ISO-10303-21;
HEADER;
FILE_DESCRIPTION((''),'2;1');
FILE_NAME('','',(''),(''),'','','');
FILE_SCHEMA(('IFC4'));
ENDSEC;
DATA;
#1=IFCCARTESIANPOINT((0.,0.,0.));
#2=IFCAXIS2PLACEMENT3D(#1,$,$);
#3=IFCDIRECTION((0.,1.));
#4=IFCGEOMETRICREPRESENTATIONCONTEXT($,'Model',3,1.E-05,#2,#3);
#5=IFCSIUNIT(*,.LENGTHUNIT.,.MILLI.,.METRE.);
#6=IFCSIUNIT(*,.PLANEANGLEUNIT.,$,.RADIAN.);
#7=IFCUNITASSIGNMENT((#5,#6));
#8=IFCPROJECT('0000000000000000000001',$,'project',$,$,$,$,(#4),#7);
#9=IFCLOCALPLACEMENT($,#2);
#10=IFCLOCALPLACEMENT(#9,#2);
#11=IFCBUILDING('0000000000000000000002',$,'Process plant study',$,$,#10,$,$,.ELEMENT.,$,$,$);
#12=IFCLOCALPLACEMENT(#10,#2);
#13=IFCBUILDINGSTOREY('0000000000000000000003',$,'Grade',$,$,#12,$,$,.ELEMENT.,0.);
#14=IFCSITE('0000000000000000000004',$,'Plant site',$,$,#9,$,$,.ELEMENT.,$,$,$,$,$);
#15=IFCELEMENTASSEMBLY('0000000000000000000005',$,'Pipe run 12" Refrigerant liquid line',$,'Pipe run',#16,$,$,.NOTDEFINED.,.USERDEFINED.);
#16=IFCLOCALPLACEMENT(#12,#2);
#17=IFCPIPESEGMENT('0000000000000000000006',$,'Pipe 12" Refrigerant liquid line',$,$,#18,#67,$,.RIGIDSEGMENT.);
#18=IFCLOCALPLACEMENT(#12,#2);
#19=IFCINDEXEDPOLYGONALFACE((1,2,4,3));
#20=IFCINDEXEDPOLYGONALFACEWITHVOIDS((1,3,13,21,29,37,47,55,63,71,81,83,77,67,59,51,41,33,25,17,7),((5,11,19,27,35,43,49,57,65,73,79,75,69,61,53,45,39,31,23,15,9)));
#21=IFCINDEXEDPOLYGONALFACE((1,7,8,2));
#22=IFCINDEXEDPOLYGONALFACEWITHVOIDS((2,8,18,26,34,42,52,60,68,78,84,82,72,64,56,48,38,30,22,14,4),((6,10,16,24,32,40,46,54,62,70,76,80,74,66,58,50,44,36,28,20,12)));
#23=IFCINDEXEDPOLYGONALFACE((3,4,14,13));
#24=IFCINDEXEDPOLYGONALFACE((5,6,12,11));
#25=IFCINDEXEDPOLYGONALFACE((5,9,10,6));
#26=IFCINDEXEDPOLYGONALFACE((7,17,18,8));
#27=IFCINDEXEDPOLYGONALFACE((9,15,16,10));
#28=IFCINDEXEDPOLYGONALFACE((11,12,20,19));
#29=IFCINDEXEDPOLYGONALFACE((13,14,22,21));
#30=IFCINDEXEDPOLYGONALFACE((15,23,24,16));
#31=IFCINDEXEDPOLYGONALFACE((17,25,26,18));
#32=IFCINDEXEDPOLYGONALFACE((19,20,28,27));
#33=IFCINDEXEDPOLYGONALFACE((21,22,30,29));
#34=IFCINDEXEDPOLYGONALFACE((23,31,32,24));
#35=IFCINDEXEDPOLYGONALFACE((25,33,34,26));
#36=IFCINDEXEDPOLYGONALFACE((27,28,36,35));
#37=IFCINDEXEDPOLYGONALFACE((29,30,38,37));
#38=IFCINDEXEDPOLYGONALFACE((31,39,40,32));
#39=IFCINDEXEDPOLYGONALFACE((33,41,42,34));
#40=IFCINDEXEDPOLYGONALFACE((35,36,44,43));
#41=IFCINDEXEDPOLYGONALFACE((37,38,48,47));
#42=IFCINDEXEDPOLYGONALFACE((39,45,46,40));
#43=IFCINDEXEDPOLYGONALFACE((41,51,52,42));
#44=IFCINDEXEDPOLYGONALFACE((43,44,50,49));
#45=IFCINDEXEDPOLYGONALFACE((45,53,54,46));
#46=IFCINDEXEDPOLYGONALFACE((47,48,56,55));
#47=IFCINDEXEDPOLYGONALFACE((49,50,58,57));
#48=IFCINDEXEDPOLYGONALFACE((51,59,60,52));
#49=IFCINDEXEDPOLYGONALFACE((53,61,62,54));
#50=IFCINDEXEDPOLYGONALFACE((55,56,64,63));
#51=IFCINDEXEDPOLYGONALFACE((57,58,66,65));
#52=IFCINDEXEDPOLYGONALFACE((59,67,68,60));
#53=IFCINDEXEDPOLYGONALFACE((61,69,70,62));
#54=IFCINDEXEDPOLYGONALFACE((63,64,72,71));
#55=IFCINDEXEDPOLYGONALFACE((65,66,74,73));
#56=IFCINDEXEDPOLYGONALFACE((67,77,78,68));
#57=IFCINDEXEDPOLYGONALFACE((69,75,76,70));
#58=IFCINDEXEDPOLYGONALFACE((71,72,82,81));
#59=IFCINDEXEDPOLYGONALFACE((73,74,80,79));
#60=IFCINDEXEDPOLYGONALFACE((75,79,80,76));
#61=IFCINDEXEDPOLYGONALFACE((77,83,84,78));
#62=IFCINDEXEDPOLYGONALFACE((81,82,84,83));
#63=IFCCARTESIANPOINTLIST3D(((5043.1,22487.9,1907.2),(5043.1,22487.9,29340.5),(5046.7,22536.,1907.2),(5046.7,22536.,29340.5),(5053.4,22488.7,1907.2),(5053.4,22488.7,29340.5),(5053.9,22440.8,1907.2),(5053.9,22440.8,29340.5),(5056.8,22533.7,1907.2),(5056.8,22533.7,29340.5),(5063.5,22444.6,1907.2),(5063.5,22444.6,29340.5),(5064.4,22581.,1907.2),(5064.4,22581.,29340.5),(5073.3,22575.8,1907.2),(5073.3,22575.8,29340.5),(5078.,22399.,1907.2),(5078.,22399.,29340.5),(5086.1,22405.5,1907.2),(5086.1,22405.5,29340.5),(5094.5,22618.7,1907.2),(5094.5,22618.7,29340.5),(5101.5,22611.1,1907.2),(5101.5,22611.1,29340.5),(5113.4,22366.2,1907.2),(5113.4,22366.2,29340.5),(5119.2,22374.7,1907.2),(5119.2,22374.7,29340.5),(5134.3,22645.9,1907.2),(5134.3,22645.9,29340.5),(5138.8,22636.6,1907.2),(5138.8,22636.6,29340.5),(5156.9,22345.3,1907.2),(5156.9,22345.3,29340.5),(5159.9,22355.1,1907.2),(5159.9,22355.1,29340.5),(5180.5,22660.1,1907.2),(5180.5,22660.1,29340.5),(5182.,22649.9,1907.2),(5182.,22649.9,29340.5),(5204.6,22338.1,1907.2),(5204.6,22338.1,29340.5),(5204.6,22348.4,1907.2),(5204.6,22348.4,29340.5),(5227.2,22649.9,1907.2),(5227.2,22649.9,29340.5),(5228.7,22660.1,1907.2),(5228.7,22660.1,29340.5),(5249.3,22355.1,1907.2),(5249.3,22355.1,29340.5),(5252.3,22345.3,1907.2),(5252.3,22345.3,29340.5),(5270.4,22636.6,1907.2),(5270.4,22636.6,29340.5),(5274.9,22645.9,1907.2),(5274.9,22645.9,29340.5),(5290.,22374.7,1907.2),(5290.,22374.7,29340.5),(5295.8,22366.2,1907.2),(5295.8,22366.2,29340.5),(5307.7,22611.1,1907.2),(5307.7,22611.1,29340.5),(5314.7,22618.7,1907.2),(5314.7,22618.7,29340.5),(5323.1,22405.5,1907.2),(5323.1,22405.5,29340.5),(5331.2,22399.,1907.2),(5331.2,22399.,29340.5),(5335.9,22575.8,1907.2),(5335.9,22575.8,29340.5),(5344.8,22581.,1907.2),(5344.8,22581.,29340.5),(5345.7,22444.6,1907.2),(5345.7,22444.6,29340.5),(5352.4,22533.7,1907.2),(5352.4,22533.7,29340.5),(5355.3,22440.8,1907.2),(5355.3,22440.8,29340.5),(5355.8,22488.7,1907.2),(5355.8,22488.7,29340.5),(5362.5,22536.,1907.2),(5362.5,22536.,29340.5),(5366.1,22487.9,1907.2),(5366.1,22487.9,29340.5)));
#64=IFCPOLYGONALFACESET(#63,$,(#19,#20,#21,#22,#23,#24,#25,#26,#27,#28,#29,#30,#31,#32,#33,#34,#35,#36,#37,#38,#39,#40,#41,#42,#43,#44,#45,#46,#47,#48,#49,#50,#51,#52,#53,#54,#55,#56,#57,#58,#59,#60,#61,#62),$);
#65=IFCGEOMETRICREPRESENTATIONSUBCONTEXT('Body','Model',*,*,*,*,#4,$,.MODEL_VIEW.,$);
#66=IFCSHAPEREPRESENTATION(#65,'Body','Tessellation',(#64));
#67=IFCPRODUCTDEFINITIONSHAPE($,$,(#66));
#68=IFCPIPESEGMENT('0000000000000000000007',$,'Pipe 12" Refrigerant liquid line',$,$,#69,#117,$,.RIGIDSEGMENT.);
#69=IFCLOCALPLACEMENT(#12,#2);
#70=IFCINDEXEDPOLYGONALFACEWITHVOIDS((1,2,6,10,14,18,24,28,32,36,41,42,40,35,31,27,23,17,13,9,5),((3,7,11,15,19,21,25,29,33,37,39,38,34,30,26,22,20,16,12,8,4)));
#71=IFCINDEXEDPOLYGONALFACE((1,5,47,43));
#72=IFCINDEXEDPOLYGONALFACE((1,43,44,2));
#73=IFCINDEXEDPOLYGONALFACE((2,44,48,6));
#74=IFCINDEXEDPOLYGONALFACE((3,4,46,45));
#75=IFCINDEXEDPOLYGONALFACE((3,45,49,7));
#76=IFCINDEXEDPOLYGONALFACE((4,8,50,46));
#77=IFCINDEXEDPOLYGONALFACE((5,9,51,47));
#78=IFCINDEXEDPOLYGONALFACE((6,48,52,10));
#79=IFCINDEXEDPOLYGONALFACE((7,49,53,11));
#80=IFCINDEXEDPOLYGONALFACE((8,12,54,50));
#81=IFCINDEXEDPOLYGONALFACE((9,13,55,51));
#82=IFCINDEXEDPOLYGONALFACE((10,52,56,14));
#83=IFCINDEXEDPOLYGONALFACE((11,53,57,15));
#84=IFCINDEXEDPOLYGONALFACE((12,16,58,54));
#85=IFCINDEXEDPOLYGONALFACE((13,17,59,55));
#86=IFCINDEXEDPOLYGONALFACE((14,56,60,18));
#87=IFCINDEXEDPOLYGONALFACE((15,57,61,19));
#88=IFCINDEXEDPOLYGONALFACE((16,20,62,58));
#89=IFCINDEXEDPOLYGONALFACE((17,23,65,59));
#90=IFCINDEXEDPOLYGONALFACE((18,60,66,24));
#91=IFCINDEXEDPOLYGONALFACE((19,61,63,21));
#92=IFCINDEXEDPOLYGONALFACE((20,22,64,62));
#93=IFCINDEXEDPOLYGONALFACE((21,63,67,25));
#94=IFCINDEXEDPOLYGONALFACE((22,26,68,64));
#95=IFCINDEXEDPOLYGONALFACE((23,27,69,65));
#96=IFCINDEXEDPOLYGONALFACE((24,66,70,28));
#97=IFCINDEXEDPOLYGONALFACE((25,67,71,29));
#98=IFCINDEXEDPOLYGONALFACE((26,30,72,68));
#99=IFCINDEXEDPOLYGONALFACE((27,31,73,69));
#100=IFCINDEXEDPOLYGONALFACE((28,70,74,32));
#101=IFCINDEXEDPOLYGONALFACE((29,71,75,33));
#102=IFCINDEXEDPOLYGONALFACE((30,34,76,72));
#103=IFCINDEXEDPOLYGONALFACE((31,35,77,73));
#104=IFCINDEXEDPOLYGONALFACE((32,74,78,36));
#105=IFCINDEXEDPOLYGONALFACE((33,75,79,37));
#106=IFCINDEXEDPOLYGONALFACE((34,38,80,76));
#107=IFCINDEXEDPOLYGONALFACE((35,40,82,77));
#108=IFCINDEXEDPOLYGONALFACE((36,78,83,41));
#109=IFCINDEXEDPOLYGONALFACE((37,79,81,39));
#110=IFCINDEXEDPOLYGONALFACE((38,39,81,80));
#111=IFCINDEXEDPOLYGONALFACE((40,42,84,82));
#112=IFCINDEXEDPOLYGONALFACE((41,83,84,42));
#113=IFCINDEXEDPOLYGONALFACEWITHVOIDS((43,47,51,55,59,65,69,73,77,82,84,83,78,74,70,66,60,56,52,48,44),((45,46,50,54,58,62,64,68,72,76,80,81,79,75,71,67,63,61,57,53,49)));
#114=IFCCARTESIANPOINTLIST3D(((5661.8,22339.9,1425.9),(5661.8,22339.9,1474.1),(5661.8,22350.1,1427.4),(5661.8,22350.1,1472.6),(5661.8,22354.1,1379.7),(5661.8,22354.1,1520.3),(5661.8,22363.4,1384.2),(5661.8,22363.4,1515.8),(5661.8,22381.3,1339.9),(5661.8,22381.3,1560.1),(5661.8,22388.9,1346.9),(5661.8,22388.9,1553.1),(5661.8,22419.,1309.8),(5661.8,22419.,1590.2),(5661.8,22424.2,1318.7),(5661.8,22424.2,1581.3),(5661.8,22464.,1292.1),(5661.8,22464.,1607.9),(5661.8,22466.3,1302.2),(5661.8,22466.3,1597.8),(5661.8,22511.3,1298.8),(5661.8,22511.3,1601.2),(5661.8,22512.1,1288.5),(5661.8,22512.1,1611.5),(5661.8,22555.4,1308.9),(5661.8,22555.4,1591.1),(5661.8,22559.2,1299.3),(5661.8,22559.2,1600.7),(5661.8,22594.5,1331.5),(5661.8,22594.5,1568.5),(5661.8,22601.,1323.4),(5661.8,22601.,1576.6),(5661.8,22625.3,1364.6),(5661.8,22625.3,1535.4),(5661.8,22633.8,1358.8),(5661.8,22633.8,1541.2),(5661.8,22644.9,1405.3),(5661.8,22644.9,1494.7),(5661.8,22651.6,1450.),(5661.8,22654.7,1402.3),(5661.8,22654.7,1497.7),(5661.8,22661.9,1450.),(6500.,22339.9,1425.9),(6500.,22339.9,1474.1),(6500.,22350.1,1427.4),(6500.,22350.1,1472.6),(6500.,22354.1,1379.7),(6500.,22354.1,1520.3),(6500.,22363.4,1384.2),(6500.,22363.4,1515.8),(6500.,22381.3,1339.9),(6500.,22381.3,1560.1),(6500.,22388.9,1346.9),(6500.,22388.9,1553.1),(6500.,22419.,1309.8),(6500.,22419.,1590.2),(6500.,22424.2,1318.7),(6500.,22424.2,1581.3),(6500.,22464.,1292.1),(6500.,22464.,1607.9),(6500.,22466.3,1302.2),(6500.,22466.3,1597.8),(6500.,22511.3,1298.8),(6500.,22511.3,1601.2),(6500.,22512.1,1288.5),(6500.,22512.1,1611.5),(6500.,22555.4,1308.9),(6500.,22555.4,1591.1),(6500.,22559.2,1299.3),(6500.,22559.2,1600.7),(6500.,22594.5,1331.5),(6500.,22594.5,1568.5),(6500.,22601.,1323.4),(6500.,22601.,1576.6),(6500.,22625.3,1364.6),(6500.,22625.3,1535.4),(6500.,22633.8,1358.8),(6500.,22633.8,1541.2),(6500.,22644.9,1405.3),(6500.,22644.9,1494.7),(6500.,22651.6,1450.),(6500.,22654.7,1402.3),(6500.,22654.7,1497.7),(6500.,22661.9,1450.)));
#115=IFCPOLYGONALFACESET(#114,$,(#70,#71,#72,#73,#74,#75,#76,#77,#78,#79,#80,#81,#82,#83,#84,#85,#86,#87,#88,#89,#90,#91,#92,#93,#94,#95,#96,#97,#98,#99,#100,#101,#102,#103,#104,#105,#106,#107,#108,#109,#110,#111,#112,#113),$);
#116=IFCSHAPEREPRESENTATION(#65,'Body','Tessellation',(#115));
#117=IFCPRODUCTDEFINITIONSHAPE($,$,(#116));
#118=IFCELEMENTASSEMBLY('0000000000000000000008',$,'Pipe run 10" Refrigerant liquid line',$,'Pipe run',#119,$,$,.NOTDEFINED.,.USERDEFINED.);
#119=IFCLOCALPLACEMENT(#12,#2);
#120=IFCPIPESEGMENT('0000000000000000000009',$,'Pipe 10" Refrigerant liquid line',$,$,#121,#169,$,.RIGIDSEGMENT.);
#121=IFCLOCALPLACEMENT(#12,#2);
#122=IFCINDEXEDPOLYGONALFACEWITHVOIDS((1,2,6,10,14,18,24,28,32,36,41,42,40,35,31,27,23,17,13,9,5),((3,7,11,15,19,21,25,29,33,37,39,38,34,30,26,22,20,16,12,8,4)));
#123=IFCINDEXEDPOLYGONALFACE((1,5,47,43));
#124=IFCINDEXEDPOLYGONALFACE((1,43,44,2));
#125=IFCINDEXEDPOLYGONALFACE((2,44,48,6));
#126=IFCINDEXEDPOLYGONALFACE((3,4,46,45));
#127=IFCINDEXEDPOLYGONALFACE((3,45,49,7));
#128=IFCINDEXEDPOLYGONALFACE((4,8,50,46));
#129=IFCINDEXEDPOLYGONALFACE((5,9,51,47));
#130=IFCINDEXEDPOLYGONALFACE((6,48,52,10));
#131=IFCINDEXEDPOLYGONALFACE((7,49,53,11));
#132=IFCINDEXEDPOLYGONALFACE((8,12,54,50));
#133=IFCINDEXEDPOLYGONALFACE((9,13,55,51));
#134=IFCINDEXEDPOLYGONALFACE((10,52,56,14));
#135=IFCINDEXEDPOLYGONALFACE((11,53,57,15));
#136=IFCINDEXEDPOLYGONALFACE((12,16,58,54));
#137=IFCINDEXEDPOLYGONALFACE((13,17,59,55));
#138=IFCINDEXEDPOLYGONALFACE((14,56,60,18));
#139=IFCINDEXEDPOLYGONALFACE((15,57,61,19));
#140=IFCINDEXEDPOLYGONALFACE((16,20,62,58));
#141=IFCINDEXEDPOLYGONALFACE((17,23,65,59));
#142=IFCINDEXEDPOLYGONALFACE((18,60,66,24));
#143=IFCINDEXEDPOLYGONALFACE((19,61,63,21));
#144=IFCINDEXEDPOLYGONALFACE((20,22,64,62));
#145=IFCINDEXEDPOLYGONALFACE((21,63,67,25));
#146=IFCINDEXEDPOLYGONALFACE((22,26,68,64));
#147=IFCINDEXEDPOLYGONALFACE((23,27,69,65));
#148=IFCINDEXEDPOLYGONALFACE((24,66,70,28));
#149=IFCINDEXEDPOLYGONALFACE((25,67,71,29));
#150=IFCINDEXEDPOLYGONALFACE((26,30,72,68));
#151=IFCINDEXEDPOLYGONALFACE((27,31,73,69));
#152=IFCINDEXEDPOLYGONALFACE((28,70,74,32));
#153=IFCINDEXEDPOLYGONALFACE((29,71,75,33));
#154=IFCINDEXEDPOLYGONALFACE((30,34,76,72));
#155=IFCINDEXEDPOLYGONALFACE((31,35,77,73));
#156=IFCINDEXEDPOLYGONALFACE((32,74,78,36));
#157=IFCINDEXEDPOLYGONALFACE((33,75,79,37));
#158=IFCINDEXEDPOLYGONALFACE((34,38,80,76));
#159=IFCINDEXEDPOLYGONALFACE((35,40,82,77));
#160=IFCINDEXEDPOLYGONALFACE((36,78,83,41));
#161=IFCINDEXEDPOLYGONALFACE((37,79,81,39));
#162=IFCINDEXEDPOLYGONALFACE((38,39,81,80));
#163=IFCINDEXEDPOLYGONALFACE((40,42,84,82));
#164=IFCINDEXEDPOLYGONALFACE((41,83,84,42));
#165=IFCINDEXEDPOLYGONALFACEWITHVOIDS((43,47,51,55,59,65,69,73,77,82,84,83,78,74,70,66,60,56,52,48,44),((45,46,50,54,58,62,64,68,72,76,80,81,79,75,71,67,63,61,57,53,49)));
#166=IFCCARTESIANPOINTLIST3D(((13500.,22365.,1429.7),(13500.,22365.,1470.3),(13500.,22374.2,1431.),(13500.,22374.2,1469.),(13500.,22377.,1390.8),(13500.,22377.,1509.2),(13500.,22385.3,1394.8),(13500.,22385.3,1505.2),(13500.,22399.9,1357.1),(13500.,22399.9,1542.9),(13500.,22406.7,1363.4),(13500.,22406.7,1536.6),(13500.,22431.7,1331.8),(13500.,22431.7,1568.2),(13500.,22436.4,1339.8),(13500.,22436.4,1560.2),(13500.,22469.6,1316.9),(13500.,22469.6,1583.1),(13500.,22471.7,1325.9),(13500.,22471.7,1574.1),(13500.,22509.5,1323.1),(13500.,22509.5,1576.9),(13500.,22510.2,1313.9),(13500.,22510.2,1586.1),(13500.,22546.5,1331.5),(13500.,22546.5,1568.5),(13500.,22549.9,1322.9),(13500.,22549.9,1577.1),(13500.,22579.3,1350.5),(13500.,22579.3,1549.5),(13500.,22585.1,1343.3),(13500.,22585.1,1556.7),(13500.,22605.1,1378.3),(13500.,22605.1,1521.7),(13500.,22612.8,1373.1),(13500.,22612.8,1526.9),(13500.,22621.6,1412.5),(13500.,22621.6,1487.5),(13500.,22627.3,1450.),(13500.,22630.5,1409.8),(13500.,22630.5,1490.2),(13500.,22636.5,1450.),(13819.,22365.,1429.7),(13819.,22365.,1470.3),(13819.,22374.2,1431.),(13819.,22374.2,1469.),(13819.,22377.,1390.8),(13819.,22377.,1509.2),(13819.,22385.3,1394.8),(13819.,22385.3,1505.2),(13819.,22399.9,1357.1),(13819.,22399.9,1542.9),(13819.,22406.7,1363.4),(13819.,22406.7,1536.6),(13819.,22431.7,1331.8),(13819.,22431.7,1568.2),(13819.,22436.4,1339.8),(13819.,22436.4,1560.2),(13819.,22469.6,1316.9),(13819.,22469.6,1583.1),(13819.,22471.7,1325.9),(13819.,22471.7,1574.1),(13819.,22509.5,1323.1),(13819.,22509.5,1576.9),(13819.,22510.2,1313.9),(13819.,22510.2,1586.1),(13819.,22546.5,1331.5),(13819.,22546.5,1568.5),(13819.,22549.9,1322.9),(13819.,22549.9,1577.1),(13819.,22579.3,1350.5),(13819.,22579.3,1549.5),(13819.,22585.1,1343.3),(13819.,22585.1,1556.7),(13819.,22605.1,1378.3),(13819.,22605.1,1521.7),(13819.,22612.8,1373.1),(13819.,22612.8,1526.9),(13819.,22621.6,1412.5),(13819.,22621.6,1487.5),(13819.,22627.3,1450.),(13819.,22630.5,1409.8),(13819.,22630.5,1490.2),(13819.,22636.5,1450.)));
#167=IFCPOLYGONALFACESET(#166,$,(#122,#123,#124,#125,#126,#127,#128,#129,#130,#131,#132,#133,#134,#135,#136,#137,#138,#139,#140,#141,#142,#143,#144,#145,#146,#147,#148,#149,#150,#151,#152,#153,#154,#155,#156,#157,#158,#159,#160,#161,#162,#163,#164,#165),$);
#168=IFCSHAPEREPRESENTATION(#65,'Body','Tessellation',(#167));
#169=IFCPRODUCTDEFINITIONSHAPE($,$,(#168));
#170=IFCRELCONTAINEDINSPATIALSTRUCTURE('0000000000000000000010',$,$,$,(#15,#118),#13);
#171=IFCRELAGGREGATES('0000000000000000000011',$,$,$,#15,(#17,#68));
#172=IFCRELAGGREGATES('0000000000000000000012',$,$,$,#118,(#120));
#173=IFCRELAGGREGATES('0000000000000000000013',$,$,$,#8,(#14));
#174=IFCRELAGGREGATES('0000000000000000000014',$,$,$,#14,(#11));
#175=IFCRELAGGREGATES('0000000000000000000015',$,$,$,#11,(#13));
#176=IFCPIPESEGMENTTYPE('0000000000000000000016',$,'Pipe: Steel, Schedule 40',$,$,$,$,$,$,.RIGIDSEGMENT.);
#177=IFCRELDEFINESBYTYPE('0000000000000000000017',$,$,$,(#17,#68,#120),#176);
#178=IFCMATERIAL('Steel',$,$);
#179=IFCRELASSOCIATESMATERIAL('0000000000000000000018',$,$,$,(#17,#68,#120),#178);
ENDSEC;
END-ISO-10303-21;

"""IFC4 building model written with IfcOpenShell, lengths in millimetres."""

from ifc_helpers import new_model, si_unit, direction, frame, origin, origin_with_axes, origin_2d, place, context, subcontext, project, spatial, hollow_circle, extrude, material, type_object, element, aggregate, save


model = new_model("IFC4")

# Units and contexts
model_context = context("Model", 3, precision=1e-05, world=origin(), true_north=direction((0.0, 1.0)))
body_context = subcontext(model_context, "Body", "Model", "MODEL_VIEW")
ifc_project = project(units=[si_unit("LENGTHUNIT", "METRE", prefix="MILLI"), si_unit("PLANEANGLEUNIT", "RADIAN")], contexts=[model_context])

# Site, building, storey
site_placement = place(None, origin())
site = spatial("IfcSite", under=ifc_project, at=site_placement, Name="Plant site", CompositionType="ELEMENT")
building_placement = place(site_placement, origin())
building = spatial("IfcBuilding", under=site, at=building_placement, Name="Process plant study", CompositionType="ELEMENT")
storey_placement = place(building_placement, origin())
storey = spatial("IfcBuildingStorey", under=building, at=storey_placement, Name="Grade", CompositionType="ELEMENT", Elevation=0.0)

# Element assemblies, pipe segments
ifc_material = material(Name="Steel")
pipe_segment_type = type_object("IfcPipeSegmentType", Name="Pipe: Steel, Schedule 40", PredefinedType="RIGIDSEGMENT")
assembly_1_placement = place(storey_placement, origin_with_axes())
assembly_1 = element("IfcElementAssembly", 1, at=assembly_1_placement, inside=storey, Name="Pipe run 12\" Refrigerant liquid line", ObjectType="Pipe run", AssemblyPlace="NOTDEFINED", PredefinedType="USERDEFINED")
pipe_segment_1_placement = place(storey_placement, origin_with_axes())
pipe_segment_1 = element("IfcPipeSegment", 2, at=pipe_segment_1_placement, type_object=pipe_segment_type, material=ifc_material, Name="Pipe 12\" Refrigerant liquid line", PredefinedType="RIGIDSEGMENT", context=body_context, shape_type="SweptSolid", body=[
    extrude(hollow_circle(Radius=161.9, WallThickness=10.3, at=origin_2d()), frame((5204.6, 22500.0, 29340.5), z_axis=(0.0, 0.0, -1.0), x_axis=(0.0, -1.0, 0.0)), (0.0, 0.0, 1.0), 27433.3),
])
pipe_segment_2_placement = place(storey_placement, origin_with_axes())
pipe_segment_2 = element("IfcPipeSegment", 3, at=pipe_segment_2_placement, type_object=pipe_segment_type, material=ifc_material, Name="Pipe 12\" Refrigerant liquid line", PredefinedType="RIGIDSEGMENT", context=body_context, shape_type="SweptSolid", body=[
    extrude(hollow_circle(Radius=161.9, WallThickness=10.3, at=origin_2d()), frame((5661.8, 22500.0, 1450.0), z_axis=(1.0, 0.0, 0.0), x_axis=(0.0, 1.0, 0.0)), (0.0, 0.0, 1.0), 838.2),
])
assembly_2_placement = place(storey_placement, origin_with_axes())
assembly_2 = element("IfcElementAssembly", 4, at=assembly_2_placement, inside=storey, Name="Pipe run 10\" Refrigerant liquid line", ObjectType="Pipe run", AssemblyPlace="NOTDEFINED", PredefinedType="USERDEFINED")
pipe_segment_3_placement = place(storey_placement, origin_with_axes())
pipe_segment_3 = element("IfcPipeSegment", 5, at=pipe_segment_3_placement, type_object=pipe_segment_type, material=ifc_material, Name="Pipe 10\" Refrigerant liquid line", PredefinedType="RIGIDSEGMENT", context=body_context, shape_type="SweptSolid", body=[
    extrude(hollow_circle(Radius=136.5, WallThickness=9.3, at=origin_2d()), frame((13500.0, 22500.0, 1450.0), z_axis=(1.0, 0.0, 0.0), x_axis=(0.0, 1.0, 0.0)), (0.0, 0.0, 1.0), 319.0),
])

aggregate(assembly_1, [pipe_segment_1, pipe_segment_2])
aggregate(assembly_2, [pipe_segment_3])

save(model, "model.ifc")
